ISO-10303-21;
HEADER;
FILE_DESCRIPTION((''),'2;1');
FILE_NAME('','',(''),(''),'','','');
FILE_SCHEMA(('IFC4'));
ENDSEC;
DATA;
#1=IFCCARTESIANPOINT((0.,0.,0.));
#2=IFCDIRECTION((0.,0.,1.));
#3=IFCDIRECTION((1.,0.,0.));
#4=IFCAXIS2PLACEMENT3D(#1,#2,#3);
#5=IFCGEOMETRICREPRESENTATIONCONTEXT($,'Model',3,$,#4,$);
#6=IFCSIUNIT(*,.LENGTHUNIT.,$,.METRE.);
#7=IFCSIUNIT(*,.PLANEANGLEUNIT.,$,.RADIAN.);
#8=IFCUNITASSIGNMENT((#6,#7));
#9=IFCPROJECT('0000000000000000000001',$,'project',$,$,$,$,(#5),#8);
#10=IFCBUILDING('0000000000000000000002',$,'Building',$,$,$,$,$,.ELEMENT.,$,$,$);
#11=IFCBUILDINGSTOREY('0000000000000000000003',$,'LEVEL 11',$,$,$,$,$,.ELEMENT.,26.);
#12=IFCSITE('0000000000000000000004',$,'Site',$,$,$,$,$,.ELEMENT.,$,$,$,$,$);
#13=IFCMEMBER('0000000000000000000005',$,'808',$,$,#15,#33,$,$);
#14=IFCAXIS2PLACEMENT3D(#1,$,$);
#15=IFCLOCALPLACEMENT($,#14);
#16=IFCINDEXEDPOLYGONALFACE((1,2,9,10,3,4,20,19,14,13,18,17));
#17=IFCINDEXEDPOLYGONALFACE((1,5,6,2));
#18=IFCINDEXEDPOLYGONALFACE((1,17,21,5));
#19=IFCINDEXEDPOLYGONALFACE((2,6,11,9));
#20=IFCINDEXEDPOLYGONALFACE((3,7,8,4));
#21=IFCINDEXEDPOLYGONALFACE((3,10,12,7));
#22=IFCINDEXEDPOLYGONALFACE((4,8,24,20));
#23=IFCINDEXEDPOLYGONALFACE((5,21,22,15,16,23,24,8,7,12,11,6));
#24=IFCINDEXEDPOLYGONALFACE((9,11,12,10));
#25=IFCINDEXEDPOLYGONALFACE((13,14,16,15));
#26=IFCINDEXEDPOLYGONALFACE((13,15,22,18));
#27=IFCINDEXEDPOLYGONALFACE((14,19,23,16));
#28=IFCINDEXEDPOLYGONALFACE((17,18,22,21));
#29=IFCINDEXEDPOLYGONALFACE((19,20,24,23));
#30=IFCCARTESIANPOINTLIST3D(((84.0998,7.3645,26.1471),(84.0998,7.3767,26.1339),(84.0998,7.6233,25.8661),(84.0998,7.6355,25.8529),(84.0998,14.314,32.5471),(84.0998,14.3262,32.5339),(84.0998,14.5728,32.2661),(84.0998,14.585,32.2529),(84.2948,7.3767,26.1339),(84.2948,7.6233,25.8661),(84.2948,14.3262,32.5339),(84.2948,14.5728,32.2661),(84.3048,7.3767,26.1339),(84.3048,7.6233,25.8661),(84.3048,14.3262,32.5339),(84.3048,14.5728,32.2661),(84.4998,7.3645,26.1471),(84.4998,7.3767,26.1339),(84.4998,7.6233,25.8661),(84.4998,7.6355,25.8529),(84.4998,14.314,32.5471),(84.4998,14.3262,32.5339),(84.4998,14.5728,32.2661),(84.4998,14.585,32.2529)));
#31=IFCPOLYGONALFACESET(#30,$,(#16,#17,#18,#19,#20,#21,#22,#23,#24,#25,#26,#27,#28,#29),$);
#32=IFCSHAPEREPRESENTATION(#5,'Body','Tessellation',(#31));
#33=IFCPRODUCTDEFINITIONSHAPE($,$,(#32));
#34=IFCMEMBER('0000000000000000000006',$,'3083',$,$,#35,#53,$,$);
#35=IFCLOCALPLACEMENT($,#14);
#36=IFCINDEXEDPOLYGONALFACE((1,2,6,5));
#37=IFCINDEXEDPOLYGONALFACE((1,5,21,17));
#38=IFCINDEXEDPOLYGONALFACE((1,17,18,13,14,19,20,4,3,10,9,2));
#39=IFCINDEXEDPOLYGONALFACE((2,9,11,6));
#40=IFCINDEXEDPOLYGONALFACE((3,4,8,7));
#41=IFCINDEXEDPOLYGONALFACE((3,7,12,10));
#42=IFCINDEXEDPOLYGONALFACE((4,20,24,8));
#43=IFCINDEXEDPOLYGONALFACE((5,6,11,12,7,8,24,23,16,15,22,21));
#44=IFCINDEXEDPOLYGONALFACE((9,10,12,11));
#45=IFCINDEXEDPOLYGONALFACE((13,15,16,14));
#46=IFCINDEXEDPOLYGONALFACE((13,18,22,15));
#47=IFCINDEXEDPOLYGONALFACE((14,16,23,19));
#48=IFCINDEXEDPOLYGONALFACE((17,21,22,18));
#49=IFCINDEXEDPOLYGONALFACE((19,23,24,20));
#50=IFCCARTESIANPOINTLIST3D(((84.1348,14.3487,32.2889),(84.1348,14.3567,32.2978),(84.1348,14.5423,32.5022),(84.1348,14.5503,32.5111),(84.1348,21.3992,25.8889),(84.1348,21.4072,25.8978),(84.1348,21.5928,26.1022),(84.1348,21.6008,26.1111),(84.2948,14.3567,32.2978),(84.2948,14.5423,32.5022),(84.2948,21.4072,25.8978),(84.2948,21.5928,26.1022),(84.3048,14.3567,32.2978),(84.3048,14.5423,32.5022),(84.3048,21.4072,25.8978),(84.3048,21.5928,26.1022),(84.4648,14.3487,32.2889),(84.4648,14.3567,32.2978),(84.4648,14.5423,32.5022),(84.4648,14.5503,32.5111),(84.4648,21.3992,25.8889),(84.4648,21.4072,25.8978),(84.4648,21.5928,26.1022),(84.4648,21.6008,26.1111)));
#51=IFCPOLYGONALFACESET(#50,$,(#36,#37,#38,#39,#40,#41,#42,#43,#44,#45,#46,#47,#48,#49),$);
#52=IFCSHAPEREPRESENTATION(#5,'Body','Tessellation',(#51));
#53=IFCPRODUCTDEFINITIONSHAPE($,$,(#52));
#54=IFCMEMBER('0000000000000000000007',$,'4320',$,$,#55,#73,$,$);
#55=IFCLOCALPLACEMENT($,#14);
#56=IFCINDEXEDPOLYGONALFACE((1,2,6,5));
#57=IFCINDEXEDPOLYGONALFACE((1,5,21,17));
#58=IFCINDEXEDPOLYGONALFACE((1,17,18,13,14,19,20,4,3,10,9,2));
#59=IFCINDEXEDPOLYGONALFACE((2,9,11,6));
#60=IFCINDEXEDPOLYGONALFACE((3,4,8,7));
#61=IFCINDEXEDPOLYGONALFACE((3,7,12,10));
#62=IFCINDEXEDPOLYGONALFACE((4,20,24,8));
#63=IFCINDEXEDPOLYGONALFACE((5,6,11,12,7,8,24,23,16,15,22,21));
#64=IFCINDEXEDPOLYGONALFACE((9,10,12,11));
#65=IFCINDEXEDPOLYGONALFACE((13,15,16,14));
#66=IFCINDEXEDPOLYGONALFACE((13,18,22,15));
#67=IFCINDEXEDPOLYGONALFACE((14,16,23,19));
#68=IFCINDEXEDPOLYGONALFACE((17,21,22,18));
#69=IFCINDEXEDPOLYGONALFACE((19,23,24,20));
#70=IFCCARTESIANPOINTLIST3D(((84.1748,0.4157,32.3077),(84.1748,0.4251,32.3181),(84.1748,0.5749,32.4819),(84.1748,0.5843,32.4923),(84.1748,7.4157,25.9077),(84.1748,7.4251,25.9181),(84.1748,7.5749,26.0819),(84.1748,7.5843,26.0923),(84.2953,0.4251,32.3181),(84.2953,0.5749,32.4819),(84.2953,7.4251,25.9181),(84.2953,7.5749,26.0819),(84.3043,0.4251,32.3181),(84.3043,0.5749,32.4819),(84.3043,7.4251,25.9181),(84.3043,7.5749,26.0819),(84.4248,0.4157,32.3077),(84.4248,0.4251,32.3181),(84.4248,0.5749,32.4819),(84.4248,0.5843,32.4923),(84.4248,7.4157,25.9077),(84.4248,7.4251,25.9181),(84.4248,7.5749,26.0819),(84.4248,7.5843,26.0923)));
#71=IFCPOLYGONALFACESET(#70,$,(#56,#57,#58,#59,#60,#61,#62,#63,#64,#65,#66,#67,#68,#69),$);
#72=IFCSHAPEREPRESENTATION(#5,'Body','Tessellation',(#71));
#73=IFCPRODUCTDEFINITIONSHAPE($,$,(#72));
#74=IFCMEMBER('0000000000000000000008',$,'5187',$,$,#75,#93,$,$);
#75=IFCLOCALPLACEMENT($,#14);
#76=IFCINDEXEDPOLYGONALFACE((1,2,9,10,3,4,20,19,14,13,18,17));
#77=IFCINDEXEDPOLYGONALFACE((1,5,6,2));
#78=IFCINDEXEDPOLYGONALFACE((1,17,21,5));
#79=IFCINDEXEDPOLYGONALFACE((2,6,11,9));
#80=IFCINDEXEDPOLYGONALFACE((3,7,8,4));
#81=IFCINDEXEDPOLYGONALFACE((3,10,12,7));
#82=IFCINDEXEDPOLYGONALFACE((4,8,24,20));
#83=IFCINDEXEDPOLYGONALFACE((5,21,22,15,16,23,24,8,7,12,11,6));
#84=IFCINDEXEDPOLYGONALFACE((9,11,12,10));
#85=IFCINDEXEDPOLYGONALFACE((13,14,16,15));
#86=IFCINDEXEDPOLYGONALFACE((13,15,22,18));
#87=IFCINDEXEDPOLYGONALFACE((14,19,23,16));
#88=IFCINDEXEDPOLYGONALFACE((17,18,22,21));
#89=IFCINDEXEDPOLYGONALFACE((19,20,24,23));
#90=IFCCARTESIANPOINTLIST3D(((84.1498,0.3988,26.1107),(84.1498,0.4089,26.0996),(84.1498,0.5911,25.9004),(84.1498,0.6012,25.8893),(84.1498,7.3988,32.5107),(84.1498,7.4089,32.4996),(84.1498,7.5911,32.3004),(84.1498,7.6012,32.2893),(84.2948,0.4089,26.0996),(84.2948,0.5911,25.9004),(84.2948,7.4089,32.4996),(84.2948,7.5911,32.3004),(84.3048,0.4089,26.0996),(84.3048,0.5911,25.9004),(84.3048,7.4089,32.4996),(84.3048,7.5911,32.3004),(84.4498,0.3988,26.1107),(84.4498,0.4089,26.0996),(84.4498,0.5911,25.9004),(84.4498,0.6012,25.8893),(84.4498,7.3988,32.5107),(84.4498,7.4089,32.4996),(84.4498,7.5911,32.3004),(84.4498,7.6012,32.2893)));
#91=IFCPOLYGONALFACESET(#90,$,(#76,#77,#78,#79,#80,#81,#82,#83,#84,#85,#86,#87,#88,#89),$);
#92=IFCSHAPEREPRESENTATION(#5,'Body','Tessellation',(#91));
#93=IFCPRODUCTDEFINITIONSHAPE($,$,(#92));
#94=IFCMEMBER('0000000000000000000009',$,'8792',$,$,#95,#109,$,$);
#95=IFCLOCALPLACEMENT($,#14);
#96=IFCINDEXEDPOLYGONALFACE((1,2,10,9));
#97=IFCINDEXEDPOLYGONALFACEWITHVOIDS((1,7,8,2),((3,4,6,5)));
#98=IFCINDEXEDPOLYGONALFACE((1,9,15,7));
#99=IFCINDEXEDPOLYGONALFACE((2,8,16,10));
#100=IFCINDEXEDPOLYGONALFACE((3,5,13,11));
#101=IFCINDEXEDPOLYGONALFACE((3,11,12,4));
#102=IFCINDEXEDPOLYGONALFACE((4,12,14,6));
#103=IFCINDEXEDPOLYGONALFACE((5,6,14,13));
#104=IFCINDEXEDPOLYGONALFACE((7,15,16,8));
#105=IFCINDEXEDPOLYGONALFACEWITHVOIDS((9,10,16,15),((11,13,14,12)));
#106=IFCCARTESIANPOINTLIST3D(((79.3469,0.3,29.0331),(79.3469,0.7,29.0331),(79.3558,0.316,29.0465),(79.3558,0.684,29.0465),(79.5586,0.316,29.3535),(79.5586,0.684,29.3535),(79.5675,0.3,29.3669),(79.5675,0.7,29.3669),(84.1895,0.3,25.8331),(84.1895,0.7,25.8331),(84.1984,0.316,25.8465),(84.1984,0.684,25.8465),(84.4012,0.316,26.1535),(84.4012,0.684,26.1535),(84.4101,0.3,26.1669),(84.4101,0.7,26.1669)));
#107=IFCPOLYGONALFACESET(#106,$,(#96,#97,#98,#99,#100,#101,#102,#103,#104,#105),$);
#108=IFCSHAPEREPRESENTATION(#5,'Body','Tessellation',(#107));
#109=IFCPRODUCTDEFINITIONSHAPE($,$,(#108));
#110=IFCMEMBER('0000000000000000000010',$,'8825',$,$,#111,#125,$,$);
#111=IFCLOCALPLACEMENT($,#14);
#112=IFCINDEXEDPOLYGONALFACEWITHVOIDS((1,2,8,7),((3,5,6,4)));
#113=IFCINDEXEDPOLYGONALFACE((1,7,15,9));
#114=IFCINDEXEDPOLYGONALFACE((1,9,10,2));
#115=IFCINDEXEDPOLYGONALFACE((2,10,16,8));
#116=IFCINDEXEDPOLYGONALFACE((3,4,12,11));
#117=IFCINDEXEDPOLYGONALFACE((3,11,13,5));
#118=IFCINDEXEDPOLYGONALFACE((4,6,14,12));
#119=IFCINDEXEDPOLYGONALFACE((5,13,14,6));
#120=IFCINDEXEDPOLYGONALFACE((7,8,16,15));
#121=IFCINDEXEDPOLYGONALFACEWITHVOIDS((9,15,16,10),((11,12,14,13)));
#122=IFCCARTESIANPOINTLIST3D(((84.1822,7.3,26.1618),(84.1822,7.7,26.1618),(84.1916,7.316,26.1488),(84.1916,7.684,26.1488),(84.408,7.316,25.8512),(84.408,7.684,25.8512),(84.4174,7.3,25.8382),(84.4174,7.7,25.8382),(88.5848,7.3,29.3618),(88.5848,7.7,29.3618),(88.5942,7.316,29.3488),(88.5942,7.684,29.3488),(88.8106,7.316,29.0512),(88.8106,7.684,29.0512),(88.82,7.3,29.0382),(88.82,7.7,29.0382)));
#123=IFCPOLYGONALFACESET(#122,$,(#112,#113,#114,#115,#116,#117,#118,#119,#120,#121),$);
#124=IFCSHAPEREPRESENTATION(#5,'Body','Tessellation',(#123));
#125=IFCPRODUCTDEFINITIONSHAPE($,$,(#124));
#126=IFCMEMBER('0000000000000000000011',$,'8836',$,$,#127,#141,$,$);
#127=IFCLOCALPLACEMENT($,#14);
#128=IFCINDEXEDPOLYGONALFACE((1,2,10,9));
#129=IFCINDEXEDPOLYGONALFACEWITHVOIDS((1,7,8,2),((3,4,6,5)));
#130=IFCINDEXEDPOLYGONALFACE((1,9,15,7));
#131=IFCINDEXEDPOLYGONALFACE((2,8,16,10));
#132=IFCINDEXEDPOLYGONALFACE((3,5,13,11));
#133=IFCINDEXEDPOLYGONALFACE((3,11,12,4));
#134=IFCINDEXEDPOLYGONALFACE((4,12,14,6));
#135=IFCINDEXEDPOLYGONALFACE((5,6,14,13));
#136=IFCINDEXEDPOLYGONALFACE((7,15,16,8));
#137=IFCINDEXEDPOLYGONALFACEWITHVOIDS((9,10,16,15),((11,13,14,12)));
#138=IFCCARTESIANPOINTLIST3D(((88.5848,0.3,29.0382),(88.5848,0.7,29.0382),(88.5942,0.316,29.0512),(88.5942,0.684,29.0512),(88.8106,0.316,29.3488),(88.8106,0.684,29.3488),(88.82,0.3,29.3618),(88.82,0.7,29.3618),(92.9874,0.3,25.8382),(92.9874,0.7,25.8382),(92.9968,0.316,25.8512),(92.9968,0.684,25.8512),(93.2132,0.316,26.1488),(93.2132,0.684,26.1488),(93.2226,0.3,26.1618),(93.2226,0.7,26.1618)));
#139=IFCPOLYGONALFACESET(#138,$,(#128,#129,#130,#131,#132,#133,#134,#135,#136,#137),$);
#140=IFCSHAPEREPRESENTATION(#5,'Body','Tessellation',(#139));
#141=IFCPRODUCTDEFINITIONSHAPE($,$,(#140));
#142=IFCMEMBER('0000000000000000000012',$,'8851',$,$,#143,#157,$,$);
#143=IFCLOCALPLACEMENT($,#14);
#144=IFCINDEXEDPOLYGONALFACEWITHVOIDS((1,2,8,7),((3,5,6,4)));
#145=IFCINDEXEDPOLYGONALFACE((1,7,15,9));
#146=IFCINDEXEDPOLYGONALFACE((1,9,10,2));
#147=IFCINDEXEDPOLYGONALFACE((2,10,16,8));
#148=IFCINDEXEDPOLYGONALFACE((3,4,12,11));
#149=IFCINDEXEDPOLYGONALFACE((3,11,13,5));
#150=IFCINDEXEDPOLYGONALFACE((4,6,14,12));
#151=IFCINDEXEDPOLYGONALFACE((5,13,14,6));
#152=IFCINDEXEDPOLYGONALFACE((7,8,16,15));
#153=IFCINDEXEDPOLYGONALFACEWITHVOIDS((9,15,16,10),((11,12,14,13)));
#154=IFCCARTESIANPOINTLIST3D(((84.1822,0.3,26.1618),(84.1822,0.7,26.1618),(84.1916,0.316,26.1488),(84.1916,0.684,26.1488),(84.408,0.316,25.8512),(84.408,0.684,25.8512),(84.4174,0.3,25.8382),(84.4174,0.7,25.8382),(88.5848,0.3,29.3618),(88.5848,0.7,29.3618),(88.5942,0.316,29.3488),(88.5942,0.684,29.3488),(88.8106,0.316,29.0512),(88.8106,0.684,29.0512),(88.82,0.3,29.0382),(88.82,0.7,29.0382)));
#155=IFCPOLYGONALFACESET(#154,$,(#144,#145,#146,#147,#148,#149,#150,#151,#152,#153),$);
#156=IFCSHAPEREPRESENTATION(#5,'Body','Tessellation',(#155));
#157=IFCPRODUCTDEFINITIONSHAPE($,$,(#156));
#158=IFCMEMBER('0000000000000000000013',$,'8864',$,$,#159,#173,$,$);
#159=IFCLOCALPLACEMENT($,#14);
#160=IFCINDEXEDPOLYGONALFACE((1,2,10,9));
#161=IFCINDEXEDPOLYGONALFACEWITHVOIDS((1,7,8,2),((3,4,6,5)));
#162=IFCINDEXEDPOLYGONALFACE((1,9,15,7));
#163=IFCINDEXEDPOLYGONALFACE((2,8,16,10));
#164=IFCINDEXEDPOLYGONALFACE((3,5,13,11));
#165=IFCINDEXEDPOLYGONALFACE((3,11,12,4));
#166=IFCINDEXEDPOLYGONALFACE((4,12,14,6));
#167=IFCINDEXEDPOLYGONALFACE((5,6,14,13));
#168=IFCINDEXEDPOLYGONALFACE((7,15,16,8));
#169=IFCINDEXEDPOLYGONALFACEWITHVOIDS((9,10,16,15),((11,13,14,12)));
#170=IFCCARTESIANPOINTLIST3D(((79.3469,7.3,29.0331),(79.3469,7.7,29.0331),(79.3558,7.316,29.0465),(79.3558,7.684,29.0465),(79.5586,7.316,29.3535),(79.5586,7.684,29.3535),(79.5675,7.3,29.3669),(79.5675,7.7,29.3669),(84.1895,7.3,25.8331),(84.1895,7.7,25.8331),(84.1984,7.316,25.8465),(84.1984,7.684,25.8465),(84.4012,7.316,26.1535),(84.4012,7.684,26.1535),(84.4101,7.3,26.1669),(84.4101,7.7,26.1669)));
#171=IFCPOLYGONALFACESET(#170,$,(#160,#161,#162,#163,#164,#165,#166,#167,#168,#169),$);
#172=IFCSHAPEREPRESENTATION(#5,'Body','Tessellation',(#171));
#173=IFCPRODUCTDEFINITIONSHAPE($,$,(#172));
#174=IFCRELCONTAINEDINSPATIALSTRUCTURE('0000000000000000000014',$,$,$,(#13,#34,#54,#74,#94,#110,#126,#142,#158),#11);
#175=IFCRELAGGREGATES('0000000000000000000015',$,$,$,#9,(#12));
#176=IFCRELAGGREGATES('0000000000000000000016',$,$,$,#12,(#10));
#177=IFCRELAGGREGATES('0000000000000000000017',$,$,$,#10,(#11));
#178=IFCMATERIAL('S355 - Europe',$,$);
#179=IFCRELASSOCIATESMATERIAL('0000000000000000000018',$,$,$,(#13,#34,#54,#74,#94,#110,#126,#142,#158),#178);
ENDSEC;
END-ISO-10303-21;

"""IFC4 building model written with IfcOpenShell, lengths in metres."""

from ifc_helpers import new_model, si_unit, frame, origin_with_axes, origin_2d_with_axis, place, context, project, spatial, hollow_rectangle, i_section, extrude, material, material_profile, profile_set, profile_usage, element, save


model = new_model("IFC4")

# Units and contexts
model_context = context("Model", 3, world=origin_with_axes())
ifc_project = project(units=[si_unit("LENGTHUNIT", "METRE"), si_unit("PLANEANGLEUNIT", "RADIAN")], contexts=[model_context])

# Site, building, storey
site = spatial("IfcSite", under=ifc_project, Name="Site", CompositionType="ELEMENT")
building = spatial("IfcBuilding", under=site, Name="Building", CompositionType="ELEMENT")
storey = spatial("IfcBuildingStorey", under=building, Name="LEVEL 11", CompositionType="ELEMENT", Elevation=26.0)

# Shared definitions
ifc_material = material(Name="S355 - Europe")

# Members
ifc_material_profile_1 = material_profile(ifc_material, i_section(OverallWidth=0.4, OverallDepth=0.4, WebThickness=0.01, FlangeThickness=0.018, at=origin_2d_with_axis()))
ifc_profile_set_1 = profile_set([ifc_material_profile_1])
ifc_profile_usage_1 = profile_usage(ifc_profile_set_1, cardinal=10)
member_1_placement = place(None, frame((84.2998, 7.5, 26.0), z_axis=(0.0, 0.73559, 0.677427), x_axis=(-1.0, 0.0, 0.0)))
element("IfcMember", 1, at=member_1_placement, inside=storey, material=ifc_profile_usage_1, Name="808", context=model_context, shape_type="SweptSolid", body=[
    extrude(i_section(OverallWidth=0.4, OverallDepth=0.4, WebThickness=0.01, FlangeThickness=0.018, at=origin_2d_with_axis()), origin_with_axes(), (0.0, 0.0, 1.0), 9.4475),
])
ifc_material_profile_2 = material_profile(ifc_material, i_section(OverallWidth=0.33, OverallDepth=0.3, WebThickness=0.01, FlangeThickness=0.012, at=origin_2d_with_axis()))
ifc_profile_set_2 = profile_set([ifc_material_profile_2])
ifc_profile_usage_2 = profile_usage(ifc_profile_set_2, cardinal=10)
member_2_placement = place(None, frame((84.2998, 14.4495, 32.4), z_axis=(0.0, 0.740439, -0.672124), x_axis=(-1.0, 0.0, 0.0)))
element("IfcMember", 2, at=member_2_placement, inside=storey, material=ifc_profile_usage_2, Name="3083", context=model_context, shape_type="SweptSolid", body=[
    extrude(i_section(OverallWidth=0.33, OverallDepth=0.3, WebThickness=0.01, FlangeThickness=0.012, at=origin_2d_with_axis()), origin_with_axes(), (0.0, 0.0, 1.0), 9.5221),
])
ifc_material_profile_3 = material_profile(ifc_material, i_section(OverallWidth=0.25, OverallDepth=0.25, WebThickness=0.009, FlangeThickness=0.014, at=origin_2d_with_axis()))
ifc_profile_set_3 = profile_set([ifc_material_profile_3])
ifc_profile_usage_3 = profile_usage(ifc_profile_set_3, cardinal=10)
member_3_placement = place(None, frame((84.2998, 0.5, 32.4), z_axis=(0.0, 0.738029, -0.674769), x_axis=(-1.0, 0.0, 0.0)))
element("IfcMember", 3, at=member_3_placement, inside=storey, material=ifc_profile_usage_3, Name="4320", context=model_context, shape_type="SweptSolid", body=[
    extrude(i_section(OverallWidth=0.25, OverallDepth=0.25, WebThickness=0.009, FlangeThickness=0.014, at=origin_2d_with_axis()), origin_with_axes(), (0.0, 0.0, 1.0), 9.4847),
])
ifc_material_profile_4 = material_profile(ifc_material, i_section(OverallWidth=0.3, OverallDepth=0.3, WebThickness=0.01, FlangeThickness=0.015, at=origin_2d_with_axis()))
ifc_profile_set_4 = profile_set([ifc_material_profile_4])
ifc_profile_usage_4 = profile_usage(ifc_profile_set_4, cardinal=10)
member_4_placement = place(None, frame((84.2998, 7.5, 32.4), z_axis=(0.0, -0.738029, -0.674769), x_axis=(1.0, 0.0, 0.0)))
element("IfcMember", 4, at=member_4_placement, inside=storey, material=ifc_profile_usage_4, Name="5187", context=model_context, shape_type="SweptSolid", body=[
    extrude(i_section(OverallWidth=0.3, OverallDepth=0.3, WebThickness=0.01, FlangeThickness=0.015, at=origin_2d_with_axis()), origin_with_axes(), (0.0, 0.0, 1.0), 9.4847),
])
ifc_material_profile_5 = material_profile(ifc_material, hollow_rectangle(XDim=0.4, YDim=0.4, WallThickness=0.016, at=origin_2d_with_axis()))
ifc_profile_set_5 = profile_set([ifc_material_profile_5])
ifc_profile_usage_5 = profile_usage(ifc_profile_set_5, cardinal=10)
member_5_placement = place(None, frame((84.2998, 0.5, 26.0), z_axis=(-0.834302, 0.0, 0.551308), x_axis=(0.0, -1.0, 0.0)))
element("IfcMember", 5, at=member_5_placement, inside=storey, material=ifc_profile_usage_5, Name="8792", context=model_context, shape_type="SweptSolid", body=[
    extrude(hollow_rectangle(XDim=0.4, YDim=0.4, WallThickness=0.016, at=origin_2d_with_axis()), origin_with_axes(), (0.0, 0.0, 1.0), 5.8044),
])
ifc_material_profile_6 = material_profile(ifc_material, hollow_rectangle(XDim=0.4, YDim=0.4, WallThickness=0.016, at=origin_2d_with_axis()))
ifc_profile_set_6 = profile_set([ifc_material_profile_6])
ifc_profile_usage_6 = profile_usage(ifc_profile_set_6, cardinal=10)
member_6_placement = place(None, frame((84.2998, 7.5, 26.0), z_axis=(0.808901, 0.0, 0.587944), x_axis=(0.0, 1.0, 0.0)))
element("IfcMember", 6, at=member_6_placement, inside=storey, material=ifc_profile_usage_6, Name="8825", context=model_context, shape_type="SweptSolid", body=[
    extrude(hollow_rectangle(XDim=0.4, YDim=0.4, WallThickness=0.016, at=origin_2d_with_axis()), origin_with_axes(), (0.0, 0.0, 1.0), 5.4427),
])
ifc_material_profile_7 = material_profile(ifc_material, hollow_rectangle(XDim=0.4, YDim=0.4, WallThickness=0.016, at=origin_2d_with_axis()))
ifc_profile_set_7 = profile_set([ifc_material_profile_7])
ifc_profile_usage_7 = profile_usage(ifc_profile_set_7, cardinal=10)
member_7_placement = place(None, frame((88.7024, 0.5, 29.2), z_axis=(0.808901, 0.0, -0.587944), x_axis=(0.0, 1.0, 0.0)))
element("IfcMember", 7, at=member_7_placement, inside=storey, material=ifc_profile_usage_7, Name="8836", context=model_context, shape_type="SweptSolid", body=[
    extrude(hollow_rectangle(XDim=0.4, YDim=0.4, WallThickness=0.016, at=origin_2d_with_axis()), origin_with_axes(), (0.0, 0.0, 1.0), 5.4427),
])
ifc_material_profile_8 = material_profile(ifc_material, hollow_rectangle(XDim=0.4, YDim=0.4, WallThickness=0.016, at=origin_2d_with_axis()))
ifc_profile_set_8 = profile_set([ifc_material_profile_8])
ifc_profile_usage_8 = profile_usage(ifc_profile_set_8, cardinal=10)
member_8_placement = place(None, frame((88.7024, 0.5, 29.2), z_axis=(-0.808901, 0.0, -0.587944), x_axis=(0.0, -1.0, 0.0)))
element("IfcMember", 8, at=member_8_placement, inside=storey, material=ifc_profile_usage_8, Name="8851", context=model_context, shape_type="SweptSolid", body=[
    extrude(hollow_rectangle(XDim=0.4, YDim=0.4, WallThickness=0.016, at=origin_2d_with_axis()), origin_with_axes(), (0.0, 0.0, 1.0), 5.4427),
])
ifc_material_profile_9 = material_profile(ifc_material, hollow_rectangle(XDim=0.4, YDim=0.4, WallThickness=0.016, at=origin_2d_with_axis()))
ifc_profile_set_9 = profile_set([ifc_material_profile_9])
ifc_profile_usage_9 = profile_usage(ifc_profile_set_9, cardinal=10)
member_9_placement = place(None, frame((79.4572, 7.5, 29.2), z_axis=(0.834302, 0.0, -0.551308), x_axis=(0.0, 1.0, 0.0)))
element("IfcMember", 9, at=member_9_placement, inside=storey, material=ifc_profile_usage_9, Name="8864", context=model_context, shape_type="SweptSolid", body=[
    extrude(hollow_rectangle(XDim=0.4, YDim=0.4, WallThickness=0.016, at=origin_2d_with_axis()), origin_with_axes(), (0.0, 0.0, 1.0), 5.8044),
])

save(model, "model.ifc")
